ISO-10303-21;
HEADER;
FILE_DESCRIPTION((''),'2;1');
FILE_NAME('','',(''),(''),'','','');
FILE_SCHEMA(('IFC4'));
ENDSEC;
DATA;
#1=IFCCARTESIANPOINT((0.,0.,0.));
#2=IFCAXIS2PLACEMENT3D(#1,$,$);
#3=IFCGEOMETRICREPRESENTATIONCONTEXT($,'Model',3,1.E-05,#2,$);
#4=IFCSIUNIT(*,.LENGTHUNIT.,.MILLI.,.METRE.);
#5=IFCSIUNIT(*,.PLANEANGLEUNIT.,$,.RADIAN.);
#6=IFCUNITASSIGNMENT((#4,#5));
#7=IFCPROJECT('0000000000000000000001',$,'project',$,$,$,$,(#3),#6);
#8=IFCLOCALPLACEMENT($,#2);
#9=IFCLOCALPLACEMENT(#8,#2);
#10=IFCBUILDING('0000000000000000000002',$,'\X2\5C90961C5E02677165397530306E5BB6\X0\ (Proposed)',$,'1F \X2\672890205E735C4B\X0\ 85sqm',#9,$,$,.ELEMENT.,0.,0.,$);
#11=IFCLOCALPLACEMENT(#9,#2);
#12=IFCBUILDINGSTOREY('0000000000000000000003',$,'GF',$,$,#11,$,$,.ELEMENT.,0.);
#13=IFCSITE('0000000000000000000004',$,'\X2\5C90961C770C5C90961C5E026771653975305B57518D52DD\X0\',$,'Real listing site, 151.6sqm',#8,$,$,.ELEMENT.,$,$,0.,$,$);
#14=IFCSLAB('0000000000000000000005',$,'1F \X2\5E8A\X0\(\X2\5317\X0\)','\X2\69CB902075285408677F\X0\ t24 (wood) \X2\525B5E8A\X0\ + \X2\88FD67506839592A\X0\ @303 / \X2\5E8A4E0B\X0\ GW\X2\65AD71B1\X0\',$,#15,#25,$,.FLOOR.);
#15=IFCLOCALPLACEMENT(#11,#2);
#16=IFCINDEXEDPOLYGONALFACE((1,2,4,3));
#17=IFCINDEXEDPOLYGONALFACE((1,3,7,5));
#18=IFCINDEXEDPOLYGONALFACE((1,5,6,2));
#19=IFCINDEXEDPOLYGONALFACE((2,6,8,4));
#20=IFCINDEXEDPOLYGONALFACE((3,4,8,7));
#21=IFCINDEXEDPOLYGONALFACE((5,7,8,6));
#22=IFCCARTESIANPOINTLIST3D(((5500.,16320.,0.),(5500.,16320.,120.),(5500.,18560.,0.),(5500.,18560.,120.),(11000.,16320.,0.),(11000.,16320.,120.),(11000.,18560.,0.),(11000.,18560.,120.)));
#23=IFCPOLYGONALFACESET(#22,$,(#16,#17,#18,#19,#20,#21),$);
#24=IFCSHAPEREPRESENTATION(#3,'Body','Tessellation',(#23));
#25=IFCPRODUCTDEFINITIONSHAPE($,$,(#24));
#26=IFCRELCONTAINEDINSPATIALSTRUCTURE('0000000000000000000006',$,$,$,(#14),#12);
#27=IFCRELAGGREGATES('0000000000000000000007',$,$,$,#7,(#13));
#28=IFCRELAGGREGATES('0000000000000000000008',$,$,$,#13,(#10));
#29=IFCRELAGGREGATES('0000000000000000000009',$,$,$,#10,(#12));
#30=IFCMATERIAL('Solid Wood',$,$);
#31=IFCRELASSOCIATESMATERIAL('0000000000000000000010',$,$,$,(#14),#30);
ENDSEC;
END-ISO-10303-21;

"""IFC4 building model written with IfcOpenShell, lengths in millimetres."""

from ifc_helpers import new_model, si_unit, frame, frame_2d, origin, place, context, project, spatial, rectangle, extrude, material, element, save


model = new_model("IFC4")

# Units and contexts
model_context = context("Model", 3, precision=1e-05, world=origin())
ifc_project = project(units=[si_unit("LENGTHUNIT", "METRE", prefix="MILLI"), si_unit("PLANEANGLEUNIT", "RADIAN")], contexts=[model_context])

# Site, building, storey
site_placement = place(None, origin())
site = spatial("IfcSite", under=ifc_project, at=site_placement, Name="岐阜県岐阜市東改田字再勝", ObjectType="Real listing site, 151.6sqm", CompositionType="ELEMENT", RefElevation=0.0)
building_placement = place(site_placement, origin())
building = spatial("IfcBuilding", under=site, at=building_placement, Name="岐阜市東改田の家 (Proposed)", ObjectType="1F 木造平屋 85sqm", CompositionType="ELEMENT", ElevationOfRefHeight=0.0, ElevationOfTerrain=0.0)
storey_placement = place(building_placement, origin())
storey = spatial("IfcBuildingStorey", under=building, at=storey_placement, Name="GF", CompositionType="ELEMENT", Elevation=0.0)

# Slab
ifc_material_1 = material(Name="Solid Wood")
slab_1_placement = place(storey_placement, frame((2750.0, 8160.0, 0.0)))
element("IfcSlab", 1, at=slab_1_placement, inside=storey, material=ifc_material_1, Name="1F 床(北)", Description="構造用合板 t24 (wood) 剛床 + 製材根太 @303 / 床下 GW断熱", PredefinedType="FLOOR", context=model_context, shape_type="SweptSolid", body=[
    extrude(rectangle(XDim=5500.0, YDim=2240.0, at=frame_2d((2750.0, 1120.0))), frame((2750.0, 8160.0, 0.0)), (0.0, 0.0, 1.0), 120.0),
])

save(model, "model.ifc")
